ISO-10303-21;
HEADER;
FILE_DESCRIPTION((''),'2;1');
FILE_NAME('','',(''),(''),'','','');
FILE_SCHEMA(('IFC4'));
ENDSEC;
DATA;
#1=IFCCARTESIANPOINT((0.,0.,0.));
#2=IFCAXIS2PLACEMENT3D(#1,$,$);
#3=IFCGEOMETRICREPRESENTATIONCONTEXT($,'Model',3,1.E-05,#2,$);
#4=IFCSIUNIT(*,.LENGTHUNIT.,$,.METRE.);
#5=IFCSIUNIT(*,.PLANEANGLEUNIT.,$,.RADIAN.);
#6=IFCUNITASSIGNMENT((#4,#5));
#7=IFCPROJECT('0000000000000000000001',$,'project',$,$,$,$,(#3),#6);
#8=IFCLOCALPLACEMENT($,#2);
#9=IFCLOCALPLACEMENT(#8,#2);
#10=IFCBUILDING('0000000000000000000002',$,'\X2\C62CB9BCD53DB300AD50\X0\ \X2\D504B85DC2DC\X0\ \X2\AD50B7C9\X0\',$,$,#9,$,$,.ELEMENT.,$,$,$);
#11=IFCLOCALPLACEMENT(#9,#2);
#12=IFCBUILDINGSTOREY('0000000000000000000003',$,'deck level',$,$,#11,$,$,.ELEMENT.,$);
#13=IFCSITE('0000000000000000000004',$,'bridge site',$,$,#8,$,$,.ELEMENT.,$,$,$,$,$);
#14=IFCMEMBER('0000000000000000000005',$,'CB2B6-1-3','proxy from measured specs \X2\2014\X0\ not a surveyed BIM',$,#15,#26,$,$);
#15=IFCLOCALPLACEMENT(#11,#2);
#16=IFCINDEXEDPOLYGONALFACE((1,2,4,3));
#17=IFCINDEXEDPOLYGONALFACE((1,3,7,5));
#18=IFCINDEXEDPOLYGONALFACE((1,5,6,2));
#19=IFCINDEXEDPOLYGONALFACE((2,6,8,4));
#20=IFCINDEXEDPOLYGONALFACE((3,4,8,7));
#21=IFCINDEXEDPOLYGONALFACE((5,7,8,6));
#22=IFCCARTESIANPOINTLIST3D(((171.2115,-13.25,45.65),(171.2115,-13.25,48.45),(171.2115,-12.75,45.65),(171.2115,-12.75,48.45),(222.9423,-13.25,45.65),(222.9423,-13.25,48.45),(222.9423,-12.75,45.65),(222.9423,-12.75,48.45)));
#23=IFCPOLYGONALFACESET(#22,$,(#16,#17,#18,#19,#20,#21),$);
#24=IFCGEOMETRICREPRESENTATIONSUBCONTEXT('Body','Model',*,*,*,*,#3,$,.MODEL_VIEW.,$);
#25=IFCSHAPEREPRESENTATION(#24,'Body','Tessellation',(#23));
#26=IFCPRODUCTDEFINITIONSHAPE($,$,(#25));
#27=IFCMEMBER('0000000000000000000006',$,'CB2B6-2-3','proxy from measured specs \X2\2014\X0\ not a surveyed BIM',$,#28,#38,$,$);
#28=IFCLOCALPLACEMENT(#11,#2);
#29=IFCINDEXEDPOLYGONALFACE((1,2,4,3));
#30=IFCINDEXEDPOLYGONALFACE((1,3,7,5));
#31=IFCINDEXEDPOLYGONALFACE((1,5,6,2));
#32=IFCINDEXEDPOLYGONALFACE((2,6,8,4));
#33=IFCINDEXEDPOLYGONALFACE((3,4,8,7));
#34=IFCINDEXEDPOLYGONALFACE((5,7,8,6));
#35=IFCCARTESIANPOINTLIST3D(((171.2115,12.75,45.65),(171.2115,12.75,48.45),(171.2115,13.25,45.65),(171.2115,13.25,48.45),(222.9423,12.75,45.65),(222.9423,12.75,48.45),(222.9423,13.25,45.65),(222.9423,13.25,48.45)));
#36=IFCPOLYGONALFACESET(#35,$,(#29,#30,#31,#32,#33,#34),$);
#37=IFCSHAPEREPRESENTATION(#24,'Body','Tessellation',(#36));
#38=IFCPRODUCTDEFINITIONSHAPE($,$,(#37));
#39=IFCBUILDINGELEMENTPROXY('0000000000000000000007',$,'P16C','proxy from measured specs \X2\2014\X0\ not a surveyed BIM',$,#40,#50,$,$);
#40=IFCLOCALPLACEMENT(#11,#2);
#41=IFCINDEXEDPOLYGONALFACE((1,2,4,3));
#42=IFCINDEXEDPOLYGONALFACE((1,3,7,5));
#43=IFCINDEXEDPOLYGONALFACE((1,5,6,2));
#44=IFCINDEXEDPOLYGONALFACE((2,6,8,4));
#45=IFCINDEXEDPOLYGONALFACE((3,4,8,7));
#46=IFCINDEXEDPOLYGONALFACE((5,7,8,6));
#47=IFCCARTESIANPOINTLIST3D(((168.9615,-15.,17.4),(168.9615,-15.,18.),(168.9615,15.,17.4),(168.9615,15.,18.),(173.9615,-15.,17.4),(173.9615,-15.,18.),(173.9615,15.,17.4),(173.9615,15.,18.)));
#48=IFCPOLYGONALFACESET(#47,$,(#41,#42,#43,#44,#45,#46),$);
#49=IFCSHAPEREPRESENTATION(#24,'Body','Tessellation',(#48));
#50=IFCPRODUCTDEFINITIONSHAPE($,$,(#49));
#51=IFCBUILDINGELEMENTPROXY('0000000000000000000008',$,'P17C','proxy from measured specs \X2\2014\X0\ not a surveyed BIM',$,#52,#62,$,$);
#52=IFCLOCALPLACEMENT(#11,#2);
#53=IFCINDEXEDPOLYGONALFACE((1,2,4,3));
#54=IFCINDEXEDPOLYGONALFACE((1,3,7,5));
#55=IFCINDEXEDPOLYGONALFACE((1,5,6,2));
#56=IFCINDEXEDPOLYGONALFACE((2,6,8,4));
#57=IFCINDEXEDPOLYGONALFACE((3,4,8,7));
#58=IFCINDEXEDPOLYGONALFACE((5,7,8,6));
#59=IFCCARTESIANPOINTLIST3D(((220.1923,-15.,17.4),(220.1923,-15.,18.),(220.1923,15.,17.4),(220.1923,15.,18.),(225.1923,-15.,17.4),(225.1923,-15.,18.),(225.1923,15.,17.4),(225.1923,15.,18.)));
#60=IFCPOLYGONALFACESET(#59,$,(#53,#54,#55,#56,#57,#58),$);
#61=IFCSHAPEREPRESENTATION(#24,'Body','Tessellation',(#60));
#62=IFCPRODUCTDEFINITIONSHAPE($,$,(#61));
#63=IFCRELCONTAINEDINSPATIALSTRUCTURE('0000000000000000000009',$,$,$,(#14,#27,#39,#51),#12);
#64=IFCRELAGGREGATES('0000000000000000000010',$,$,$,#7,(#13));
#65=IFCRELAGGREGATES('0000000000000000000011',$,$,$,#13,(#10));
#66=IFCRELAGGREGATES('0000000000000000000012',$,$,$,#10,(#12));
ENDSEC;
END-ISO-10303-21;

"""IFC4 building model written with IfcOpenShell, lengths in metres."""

from ifc_helpers import new_model, si_unit, frame, origin, origin_2d, place, context, subcontext, project, spatial, rectangle, extrude, element, save


model = new_model("IFC4")

# Units and contexts
model_context = context("Model", 3, precision=1e-05, world=origin())
body_context = subcontext(model_context, "Body", "Model", "MODEL_VIEW")
ifc_project = project(units=[si_unit("LENGTHUNIT", "METRE"), si_unit("PLANEANGLEUNIT", "RADIAN")], contexts=[model_context])

# Site, building, storey
site_placement = place(None, origin())
site = spatial("IfcSite", under=ifc_project, at=site_placement, Name="bridge site", CompositionType="ELEMENT")
building_placement = place(site_placement, origin())
building = spatial("IfcBuilding", under=site, at=building_placement, Name="올림픽대교 프록시 교량", CompositionType="ELEMENT")
storey_placement = place(building_placement, origin())
storey = spatial("IfcBuildingStorey", under=building, at=storey_placement, Name="deck level", CompositionType="ELEMENT")

# Members
for number, where, name in (
    (1, (197.0769, -13.0, 45.65), "CB2B6-1-3"),
    (2, (197.0769, 13.0, 45.65), "CB2B6-2-3"),
):
    element("IfcMember", number, at=place(storey_placement, frame(where)), inside=storey, Name=name, Description="proxy from measured specs — not a surveyed BIM", context=body_context, shape_type="SweptSolid", body=[
        extrude(rectangle(XDim=51.7308, YDim=0.5, at=origin_2d()), origin(), (0.0, 0.0, 1.0), 2.8),
    ])

# Building element proxies
for number, where, name in (
    (3, (171.4615, 0.0, 17.4), "P16C"),
    (4, (222.6923, 0.0, 17.4), "P17C"),
):
    element("IfcBuildingElementProxy", number, at=place(storey_placement, frame(where)), inside=storey, Name=name, Description="proxy from measured specs — not a surveyed BIM", context=body_context, shape_type="SweptSolid", body=[
        extrude(rectangle(XDim=5.0, YDim=30.0, at=origin_2d()), origin(), (0.0, 0.0, 1.0), 0.6),
    ])

save(model, "model.ifc")
